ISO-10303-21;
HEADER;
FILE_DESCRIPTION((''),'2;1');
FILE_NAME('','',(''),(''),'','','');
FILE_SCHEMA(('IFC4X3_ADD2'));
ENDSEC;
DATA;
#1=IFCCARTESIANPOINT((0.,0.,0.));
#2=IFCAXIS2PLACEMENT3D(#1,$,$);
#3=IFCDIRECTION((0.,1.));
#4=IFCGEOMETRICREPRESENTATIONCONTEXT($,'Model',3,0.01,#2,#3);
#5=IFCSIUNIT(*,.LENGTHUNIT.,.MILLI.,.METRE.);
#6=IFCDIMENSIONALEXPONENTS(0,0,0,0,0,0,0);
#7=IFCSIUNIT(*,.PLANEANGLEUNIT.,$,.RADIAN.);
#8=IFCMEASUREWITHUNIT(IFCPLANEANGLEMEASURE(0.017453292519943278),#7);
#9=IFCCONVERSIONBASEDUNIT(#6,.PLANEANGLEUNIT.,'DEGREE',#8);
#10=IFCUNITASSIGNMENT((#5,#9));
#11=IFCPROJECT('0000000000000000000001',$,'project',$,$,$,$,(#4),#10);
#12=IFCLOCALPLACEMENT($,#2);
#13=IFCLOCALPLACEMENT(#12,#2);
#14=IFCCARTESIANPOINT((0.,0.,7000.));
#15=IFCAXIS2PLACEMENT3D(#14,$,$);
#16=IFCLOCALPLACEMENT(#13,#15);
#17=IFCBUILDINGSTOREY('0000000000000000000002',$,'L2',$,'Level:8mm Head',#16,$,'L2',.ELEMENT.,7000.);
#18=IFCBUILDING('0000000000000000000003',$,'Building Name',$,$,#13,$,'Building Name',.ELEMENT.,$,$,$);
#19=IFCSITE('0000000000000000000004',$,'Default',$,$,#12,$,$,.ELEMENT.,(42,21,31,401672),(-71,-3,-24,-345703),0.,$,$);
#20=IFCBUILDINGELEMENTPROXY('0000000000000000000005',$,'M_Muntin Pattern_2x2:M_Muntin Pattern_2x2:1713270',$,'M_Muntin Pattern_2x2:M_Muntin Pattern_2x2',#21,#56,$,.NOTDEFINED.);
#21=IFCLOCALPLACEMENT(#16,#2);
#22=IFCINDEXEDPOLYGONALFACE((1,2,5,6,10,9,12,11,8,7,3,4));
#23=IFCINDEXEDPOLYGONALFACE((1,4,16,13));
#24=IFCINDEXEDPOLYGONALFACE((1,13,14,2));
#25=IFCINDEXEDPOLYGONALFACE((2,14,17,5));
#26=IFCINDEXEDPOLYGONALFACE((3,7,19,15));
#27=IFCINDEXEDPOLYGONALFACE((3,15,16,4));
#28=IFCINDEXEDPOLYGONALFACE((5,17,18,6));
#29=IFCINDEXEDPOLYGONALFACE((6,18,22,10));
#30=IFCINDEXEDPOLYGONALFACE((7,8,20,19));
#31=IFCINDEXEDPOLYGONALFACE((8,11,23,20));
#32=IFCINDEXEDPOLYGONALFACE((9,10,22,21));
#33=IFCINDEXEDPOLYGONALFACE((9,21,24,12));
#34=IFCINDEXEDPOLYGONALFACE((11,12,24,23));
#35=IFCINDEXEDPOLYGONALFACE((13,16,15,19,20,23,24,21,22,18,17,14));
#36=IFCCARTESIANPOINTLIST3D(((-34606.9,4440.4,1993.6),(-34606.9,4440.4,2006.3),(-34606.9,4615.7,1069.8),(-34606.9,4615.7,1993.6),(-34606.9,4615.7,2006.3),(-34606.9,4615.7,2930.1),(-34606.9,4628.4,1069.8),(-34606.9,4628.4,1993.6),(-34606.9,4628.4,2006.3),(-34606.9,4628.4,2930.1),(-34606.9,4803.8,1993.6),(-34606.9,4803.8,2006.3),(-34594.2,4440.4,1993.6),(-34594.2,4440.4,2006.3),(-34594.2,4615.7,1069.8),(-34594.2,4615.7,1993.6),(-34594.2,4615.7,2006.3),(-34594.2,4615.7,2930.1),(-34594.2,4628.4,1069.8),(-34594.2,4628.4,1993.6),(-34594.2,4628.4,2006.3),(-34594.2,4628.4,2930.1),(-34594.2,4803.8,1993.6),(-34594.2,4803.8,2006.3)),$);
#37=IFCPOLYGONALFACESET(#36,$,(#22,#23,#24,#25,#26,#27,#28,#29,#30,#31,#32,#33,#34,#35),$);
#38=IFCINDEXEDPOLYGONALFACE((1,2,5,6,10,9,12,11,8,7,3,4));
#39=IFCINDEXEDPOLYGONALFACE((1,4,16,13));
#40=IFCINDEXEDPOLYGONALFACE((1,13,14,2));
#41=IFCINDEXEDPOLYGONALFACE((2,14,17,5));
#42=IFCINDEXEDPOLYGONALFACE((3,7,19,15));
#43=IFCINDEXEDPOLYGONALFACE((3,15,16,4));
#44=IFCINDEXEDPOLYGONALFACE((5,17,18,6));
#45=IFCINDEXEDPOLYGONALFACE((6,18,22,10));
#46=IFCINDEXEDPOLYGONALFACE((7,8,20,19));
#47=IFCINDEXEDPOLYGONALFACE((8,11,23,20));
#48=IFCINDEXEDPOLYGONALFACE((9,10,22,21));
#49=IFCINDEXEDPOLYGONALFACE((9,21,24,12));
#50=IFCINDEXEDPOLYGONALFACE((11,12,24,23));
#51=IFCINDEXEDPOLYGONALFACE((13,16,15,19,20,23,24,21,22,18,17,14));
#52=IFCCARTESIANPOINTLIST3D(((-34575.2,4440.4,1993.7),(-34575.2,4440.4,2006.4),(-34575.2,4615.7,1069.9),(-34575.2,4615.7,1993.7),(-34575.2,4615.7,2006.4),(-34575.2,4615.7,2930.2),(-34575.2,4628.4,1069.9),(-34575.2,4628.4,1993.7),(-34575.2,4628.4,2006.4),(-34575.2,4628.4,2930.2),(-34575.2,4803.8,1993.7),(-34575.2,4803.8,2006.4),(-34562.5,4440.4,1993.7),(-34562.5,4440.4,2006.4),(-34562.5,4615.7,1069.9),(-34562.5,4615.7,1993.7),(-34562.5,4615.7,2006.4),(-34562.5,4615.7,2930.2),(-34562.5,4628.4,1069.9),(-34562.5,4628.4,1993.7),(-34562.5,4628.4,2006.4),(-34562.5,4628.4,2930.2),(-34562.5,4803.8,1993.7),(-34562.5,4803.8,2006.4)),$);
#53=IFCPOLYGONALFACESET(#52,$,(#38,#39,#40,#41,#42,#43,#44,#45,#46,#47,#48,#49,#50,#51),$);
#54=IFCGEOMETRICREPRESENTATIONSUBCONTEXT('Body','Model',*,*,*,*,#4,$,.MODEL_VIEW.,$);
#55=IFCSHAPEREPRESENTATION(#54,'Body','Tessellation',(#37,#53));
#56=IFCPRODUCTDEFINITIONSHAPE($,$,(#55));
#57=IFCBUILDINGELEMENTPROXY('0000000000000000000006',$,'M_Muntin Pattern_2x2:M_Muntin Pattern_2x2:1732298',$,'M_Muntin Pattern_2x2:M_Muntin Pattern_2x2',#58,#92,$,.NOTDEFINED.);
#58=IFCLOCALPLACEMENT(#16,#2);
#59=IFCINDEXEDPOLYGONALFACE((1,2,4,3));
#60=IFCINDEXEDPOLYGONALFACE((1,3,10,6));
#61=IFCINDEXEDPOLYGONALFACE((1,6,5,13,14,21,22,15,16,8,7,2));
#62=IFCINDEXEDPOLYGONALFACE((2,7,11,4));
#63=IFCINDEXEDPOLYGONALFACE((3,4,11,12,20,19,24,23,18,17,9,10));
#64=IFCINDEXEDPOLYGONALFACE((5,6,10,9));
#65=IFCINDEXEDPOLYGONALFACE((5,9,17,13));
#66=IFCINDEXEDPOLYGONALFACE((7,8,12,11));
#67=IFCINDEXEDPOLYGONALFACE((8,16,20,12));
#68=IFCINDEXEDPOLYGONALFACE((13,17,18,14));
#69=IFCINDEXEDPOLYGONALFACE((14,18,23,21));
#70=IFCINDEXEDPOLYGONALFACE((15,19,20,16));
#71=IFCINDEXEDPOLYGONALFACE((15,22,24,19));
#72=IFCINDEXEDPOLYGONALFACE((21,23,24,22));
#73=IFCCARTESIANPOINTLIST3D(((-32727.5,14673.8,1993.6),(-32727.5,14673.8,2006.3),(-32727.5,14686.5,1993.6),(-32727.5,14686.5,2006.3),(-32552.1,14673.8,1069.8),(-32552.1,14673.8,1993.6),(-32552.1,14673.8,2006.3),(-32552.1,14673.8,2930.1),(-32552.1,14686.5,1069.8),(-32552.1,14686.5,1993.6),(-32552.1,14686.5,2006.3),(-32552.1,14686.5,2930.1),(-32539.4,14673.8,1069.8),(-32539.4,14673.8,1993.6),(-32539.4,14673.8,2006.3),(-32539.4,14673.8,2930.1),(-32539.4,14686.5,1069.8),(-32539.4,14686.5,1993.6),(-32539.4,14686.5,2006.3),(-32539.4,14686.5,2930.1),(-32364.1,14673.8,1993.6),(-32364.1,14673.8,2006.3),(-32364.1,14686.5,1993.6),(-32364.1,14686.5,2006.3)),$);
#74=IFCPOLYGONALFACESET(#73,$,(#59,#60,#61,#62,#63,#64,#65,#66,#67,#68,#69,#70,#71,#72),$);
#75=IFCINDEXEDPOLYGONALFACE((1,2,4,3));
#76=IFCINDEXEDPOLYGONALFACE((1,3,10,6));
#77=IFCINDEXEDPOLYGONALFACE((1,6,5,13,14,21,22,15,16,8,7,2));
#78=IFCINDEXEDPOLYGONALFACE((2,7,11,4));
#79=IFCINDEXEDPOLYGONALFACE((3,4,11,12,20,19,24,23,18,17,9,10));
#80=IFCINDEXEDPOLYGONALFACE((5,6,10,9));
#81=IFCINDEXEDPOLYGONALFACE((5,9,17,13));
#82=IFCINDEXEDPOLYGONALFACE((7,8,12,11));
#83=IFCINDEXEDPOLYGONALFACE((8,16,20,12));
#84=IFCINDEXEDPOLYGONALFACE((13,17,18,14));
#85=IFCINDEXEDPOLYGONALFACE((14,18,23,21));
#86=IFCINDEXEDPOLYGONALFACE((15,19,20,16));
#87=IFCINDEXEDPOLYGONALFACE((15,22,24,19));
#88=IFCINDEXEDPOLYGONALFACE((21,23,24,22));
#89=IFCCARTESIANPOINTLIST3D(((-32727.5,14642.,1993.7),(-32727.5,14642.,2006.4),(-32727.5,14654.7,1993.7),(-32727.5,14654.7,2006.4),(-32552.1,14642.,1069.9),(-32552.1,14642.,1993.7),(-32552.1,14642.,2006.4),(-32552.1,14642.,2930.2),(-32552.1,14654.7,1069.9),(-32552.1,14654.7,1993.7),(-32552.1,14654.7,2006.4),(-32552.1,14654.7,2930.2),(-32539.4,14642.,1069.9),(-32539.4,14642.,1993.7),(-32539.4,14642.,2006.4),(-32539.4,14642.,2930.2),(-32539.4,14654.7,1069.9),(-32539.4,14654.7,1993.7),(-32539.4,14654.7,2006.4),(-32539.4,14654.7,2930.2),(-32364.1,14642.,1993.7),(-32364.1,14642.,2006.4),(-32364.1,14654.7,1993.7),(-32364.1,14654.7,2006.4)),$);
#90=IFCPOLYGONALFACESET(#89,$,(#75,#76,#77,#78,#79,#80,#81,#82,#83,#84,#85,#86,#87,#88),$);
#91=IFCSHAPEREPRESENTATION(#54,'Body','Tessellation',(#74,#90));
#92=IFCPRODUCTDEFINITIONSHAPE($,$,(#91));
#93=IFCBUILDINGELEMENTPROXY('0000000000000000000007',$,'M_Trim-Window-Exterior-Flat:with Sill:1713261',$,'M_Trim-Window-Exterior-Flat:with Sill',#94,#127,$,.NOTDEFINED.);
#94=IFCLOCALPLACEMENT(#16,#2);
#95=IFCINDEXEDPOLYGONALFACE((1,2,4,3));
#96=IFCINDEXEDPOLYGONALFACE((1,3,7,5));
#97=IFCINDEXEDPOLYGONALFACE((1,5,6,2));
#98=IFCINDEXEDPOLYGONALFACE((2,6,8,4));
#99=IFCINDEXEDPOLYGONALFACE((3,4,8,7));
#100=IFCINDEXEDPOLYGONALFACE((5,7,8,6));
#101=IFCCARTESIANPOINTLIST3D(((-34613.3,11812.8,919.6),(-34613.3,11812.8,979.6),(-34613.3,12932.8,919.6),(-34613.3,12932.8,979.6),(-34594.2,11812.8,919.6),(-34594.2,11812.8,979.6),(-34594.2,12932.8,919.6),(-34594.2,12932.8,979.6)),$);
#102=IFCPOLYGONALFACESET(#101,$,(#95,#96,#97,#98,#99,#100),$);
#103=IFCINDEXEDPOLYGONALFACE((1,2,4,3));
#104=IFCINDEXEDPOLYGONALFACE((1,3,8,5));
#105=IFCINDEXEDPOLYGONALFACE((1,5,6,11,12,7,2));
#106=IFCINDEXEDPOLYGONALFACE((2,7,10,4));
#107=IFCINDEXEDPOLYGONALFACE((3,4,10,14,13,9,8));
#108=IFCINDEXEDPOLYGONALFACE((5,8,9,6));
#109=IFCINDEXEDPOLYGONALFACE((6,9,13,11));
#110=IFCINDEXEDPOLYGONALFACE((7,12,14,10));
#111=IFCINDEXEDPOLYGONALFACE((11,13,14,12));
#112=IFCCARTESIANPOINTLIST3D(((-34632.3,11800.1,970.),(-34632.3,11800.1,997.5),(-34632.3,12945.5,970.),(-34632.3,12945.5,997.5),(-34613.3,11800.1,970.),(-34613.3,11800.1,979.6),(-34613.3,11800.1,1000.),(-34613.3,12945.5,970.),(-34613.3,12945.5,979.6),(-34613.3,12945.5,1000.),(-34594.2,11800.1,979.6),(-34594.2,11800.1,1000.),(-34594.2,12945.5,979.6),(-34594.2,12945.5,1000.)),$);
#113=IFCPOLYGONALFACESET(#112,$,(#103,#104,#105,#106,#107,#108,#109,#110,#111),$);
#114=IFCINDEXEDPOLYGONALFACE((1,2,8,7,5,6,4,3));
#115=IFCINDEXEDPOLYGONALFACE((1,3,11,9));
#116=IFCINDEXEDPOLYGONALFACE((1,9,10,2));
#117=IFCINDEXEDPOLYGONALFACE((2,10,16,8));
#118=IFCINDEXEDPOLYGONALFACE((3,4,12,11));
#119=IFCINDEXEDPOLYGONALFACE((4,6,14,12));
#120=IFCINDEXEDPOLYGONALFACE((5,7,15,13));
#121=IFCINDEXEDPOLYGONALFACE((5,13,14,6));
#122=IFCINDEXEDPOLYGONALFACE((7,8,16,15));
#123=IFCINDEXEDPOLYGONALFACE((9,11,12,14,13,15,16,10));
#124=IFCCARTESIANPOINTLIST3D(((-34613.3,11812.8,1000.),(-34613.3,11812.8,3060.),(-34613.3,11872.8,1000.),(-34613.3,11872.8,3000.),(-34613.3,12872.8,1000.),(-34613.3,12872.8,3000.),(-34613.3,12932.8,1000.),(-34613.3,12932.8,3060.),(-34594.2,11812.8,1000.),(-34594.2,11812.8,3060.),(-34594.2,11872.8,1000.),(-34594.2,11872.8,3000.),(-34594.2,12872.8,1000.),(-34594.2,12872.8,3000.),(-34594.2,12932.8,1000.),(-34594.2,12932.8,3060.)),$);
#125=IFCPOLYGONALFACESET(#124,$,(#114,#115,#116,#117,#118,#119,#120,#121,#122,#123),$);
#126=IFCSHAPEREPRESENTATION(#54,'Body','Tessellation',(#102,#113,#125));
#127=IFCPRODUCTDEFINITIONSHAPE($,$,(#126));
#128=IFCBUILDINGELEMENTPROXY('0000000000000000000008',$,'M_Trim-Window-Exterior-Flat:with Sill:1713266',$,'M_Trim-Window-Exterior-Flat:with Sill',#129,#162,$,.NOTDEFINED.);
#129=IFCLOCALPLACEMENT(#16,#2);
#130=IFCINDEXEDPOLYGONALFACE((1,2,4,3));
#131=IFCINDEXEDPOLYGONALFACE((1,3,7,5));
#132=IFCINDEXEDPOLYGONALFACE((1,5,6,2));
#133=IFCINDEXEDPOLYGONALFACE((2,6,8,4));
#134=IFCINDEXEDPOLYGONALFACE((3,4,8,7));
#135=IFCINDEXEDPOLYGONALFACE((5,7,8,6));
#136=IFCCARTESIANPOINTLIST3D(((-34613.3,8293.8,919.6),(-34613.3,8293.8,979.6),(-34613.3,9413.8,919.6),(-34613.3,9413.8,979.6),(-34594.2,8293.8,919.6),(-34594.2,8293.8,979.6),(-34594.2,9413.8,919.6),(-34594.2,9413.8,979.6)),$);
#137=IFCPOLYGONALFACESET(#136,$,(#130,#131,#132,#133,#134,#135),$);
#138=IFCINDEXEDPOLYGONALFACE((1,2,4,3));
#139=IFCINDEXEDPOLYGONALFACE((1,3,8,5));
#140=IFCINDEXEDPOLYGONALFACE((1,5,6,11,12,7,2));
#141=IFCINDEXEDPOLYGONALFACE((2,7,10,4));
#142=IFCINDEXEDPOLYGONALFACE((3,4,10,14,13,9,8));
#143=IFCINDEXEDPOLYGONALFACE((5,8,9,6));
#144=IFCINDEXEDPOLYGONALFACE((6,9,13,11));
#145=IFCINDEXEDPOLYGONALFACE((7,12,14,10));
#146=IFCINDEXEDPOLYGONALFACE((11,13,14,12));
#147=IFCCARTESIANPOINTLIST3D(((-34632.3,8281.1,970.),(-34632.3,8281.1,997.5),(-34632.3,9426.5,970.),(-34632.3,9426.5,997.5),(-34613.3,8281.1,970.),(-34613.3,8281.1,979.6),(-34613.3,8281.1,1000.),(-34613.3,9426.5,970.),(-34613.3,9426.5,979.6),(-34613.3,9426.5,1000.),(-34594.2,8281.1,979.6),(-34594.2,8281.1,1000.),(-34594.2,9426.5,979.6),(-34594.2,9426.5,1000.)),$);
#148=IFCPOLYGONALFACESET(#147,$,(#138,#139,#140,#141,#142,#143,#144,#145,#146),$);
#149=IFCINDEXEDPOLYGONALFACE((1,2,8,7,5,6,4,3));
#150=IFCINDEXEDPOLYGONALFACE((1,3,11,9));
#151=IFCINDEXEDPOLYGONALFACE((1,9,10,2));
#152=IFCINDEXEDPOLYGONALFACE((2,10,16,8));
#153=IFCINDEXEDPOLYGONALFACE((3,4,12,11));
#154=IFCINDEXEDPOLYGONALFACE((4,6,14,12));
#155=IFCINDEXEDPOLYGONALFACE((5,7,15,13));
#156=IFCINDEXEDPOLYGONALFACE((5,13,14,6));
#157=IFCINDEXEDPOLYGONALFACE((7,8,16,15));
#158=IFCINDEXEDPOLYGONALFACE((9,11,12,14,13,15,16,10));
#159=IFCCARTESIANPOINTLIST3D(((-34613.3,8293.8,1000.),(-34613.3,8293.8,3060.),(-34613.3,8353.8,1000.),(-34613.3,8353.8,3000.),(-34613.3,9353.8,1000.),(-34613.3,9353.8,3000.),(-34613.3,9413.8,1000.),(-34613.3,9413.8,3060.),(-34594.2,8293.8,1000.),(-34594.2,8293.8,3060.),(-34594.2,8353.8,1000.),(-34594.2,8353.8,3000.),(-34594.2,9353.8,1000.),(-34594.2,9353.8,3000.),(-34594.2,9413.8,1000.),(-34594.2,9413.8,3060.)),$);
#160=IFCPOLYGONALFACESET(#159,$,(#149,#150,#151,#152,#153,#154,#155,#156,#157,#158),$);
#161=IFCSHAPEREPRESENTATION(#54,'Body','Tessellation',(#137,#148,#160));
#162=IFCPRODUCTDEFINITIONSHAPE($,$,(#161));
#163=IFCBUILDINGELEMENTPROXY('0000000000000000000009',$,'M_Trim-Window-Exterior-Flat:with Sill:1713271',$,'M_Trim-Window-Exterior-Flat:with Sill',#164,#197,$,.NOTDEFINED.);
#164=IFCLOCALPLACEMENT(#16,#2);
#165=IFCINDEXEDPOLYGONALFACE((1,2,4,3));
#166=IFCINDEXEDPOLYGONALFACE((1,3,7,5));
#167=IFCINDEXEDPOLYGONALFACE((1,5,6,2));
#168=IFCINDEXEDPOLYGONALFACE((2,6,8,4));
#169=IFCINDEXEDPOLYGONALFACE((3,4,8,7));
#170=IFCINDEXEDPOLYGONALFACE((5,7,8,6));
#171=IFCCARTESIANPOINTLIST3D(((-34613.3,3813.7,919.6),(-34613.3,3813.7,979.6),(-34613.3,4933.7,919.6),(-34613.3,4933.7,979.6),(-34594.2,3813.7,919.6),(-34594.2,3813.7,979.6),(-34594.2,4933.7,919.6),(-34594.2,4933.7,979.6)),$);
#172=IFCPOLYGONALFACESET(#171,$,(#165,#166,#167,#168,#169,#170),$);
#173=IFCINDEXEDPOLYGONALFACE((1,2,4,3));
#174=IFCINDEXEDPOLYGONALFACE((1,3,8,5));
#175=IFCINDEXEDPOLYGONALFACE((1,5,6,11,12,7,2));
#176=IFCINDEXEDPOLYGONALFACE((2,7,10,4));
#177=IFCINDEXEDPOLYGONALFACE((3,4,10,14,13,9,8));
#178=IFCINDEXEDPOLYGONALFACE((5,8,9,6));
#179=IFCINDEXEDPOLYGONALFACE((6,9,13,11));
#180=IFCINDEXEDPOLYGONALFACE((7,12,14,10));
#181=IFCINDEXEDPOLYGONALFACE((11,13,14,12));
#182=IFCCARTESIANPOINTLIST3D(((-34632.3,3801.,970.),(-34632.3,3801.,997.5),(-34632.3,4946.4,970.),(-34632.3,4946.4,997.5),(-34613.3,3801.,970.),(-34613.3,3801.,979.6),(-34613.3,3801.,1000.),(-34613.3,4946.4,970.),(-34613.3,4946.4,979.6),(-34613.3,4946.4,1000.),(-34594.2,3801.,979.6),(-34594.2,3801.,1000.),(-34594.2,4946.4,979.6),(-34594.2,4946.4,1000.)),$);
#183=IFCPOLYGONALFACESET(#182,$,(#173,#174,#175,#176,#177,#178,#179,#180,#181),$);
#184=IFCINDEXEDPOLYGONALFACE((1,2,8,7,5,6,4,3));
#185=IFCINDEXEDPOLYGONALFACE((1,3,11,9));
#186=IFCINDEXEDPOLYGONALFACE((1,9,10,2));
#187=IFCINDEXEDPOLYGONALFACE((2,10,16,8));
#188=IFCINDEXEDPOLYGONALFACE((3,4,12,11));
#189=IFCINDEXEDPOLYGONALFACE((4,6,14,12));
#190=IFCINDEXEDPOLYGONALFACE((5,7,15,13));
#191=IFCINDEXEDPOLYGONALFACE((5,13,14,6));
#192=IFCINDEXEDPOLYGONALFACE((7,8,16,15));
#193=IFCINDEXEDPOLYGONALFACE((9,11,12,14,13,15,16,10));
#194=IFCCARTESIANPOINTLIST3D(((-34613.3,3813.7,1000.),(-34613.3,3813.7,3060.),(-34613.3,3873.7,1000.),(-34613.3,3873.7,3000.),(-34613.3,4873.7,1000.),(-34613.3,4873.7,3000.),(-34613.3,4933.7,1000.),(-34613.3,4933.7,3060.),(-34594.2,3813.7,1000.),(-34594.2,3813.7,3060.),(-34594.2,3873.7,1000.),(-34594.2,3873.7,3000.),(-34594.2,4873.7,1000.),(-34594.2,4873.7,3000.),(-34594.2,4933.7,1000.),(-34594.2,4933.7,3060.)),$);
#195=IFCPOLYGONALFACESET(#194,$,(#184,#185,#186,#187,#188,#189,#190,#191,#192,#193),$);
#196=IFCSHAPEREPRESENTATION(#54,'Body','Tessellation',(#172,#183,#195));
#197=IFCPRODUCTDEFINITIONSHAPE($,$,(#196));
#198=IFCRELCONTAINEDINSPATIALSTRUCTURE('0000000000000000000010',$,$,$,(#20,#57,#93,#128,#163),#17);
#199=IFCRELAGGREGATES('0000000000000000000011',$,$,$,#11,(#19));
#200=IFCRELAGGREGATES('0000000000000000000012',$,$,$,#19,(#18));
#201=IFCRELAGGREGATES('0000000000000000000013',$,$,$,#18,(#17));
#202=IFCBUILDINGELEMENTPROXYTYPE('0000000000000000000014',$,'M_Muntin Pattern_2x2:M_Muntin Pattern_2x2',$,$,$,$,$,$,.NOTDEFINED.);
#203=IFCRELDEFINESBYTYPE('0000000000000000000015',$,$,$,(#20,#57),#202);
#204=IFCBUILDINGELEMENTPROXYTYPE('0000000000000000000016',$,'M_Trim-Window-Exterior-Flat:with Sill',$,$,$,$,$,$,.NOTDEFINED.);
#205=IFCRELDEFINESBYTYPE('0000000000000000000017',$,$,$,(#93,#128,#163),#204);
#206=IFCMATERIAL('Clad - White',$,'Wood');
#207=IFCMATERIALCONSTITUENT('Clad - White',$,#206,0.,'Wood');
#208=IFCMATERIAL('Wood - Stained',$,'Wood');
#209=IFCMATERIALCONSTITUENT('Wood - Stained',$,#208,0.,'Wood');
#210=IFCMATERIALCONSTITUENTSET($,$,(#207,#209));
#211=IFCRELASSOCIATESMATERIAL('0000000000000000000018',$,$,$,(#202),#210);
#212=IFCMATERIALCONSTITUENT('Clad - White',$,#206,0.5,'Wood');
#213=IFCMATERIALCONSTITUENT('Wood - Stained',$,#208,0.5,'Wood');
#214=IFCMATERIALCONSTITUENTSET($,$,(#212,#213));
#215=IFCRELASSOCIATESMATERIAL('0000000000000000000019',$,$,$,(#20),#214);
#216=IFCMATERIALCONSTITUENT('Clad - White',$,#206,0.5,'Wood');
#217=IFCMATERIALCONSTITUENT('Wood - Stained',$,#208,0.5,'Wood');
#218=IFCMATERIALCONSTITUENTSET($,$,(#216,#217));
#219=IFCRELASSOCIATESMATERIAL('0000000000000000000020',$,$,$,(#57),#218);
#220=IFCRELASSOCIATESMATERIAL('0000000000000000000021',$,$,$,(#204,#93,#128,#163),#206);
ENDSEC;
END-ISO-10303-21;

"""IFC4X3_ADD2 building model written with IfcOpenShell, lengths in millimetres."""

from ifc_helpers import new_model, entity, si_unit, converted_unit, direction, frame, frame_2d, origin, place, context, subcontext, project, spatial, polyline, rectangle, outline, extrude, source, transform, mapped, material, constituent, constituent_set, type_object, type_shapes, element, save


model = new_model("IFC4X3_ADD2")

# Units and contexts
model_context = context("Model", 3, precision=0.01, world=origin(), true_north=direction((0.0, 1.0)))
body_context = subcontext(model_context, "Body", "Model", "MODEL_VIEW")
ifc_project = project(units=[si_unit("LENGTHUNIT", "METRE", prefix="MILLI"), converted_unit("PLANEANGLEUNIT", "DEGREE", entity("IfcPlaneAngleMeasure", 0.017453292519943278), si_unit("PLANEANGLEUNIT", "RADIAN"), dimensions=[0, 0, 0, 0, 0, 0, 0])], contexts=[model_context])

# Site, building, storey
site_placement = place(None, origin())
site = spatial("IfcSite", under=ifc_project, at=site_placement, Name="Default", CompositionType="ELEMENT", RefLatitude=(42, 21, 31, 401672), RefLongitude=(-71, -3, -24, -345703), RefElevation=0.0)
building_placement = place(site_placement, origin())
building = spatial("IfcBuilding", under=site, at=building_placement, Name="Building Name", LongName="Building Name", CompositionType="ELEMENT")
storey_placement = place(building_placement, frame((0.0, 0.0, 7000.0)))
storey = spatial("IfcBuildingStorey", under=building, at=storey_placement, Name="L2", ObjectType="Level:8mm Head", LongName="L2", CompositionType="ELEMENT", Elevation=7000.0)

# Building element proxies
ifc_material_1 = material(Name="Clad - White", Category="Wood")
ifc_material_2 = material(Name="Wood - Stained", Category="Wood")
ifc_constituent_1 = constituent(ifc_material_1, Name="Clad - White", Category="Wood", fraction=0.0)
ifc_constituent_2 = constituent(ifc_material_2, Name="Wood - Stained", Category="Wood", fraction=0.0)
ifc_constituent_set_1 = constituent_set(constituents=[ifc_constituent_1, ifc_constituent_2])
building_element_proxy_type_1 = type_object("IfcBuildingElementProxyType", Name="M_Muntin Pattern_2x2:M_Muntin Pattern_2x2", PredefinedType="NOTDEFINED", material=ifc_constituent_set_1)
shared_shape_1 = source(origin(), body_context, "Body", "SweptSolid", [
    extrude(outline(polyline([(6.4, -6.4), (930.1, -6.4), (930.1, 6.3), (6.4, 6.3), (6.4, 181.7), (-6.3, 181.7), (-6.3, 6.3), (-930.2, 6.3), (-930.2, -6.4), (-6.3, -6.4), (-6.3, -181.7), (6.4, -181.7), (6.4, -6.4)])), frame((0.0, -22.2, 930.1), z_axis=(0.0, 1.0, 0.0), x_axis=(0.0, 0.0, 1.0)), (0.0, 0.0, 1.0), 12.7),
    extrude(outline(polyline([(6.4, -6.4), (930.2, -6.4), (930.2, 6.3), (6.4, 6.3), (6.4, 181.7), (-6.3, 181.7), (-6.3, 6.3), (-930.2, 6.3), (-930.2, -6.4), (-6.3, -6.4), (-6.3, -181.7), (6.4, -181.7), (6.4, -6.4)])), frame((0.0, 9.5, 930.2), z_axis=(0.0, 1.0, 0.0), x_axis=(0.0, 0.0, 1.0)), (0.0, 0.0, 1.0), 12.7),
])
type_shapes(building_element_proxy_type_1, [shared_shape_1])
ifc_constituent_3 = constituent(ifc_material_1, Name="Clad - White", Category="Wood", fraction=0.5)
ifc_constituent_4 = constituent(ifc_material_2, Name="Wood - Stained", Category="Wood", fraction=0.5)
ifc_constituent_set_2 = constituent_set(constituents=[ifc_constituent_3, ifc_constituent_4])
proxy_1_placement = place(storey_placement, frame((-34584.7, 4622.1, 1069.9), z_axis=(0.0, 0.0, 1.0), x_axis=(0.0, -1.0, 0.0)))
element("IfcBuildingElementProxy", 1, at=proxy_1_placement, inside=storey, type_object=building_element_proxy_type_1, material=ifc_constituent_set_2, Name="M_Muntin Pattern_2x2:M_Muntin Pattern_2x2:1713270", ObjectType="M_Muntin Pattern_2x2:M_Muntin Pattern_2x2", PredefinedType="NOTDEFINED", context=body_context, shape_type="MappedRepresentation", body=[
    mapped(shared_shape_1, transform((0.0, 0.0, 0.0), scale=1.0)),
])
ifc_constituent_5 = constituent(ifc_material_1, Name="Clad - White", Category="Wood", fraction=0.5)
ifc_constituent_6 = constituent(ifc_material_2, Name="Wood - Stained", Category="Wood", fraction=0.5)
ifc_constituent_set_3 = constituent_set(constituents=[ifc_constituent_5, ifc_constituent_6])
proxy_2_placement = place(storey_placement, frame((-32545.8, 14664.3, 1069.9), z_axis=(0.0, 0.0, 1.0), x_axis=(-1.0, 0.0, 0.0)))
element("IfcBuildingElementProxy", 2, at=proxy_2_placement, inside=storey, type_object=building_element_proxy_type_1, material=ifc_constituent_set_3, Name="M_Muntin Pattern_2x2:M_Muntin Pattern_2x2:1732298", ObjectType="M_Muntin Pattern_2x2:M_Muntin Pattern_2x2", PredefinedType="NOTDEFINED", context=body_context, shape_type="MappedRepresentation", body=[
    mapped(shared_shape_1, transform((0.0, 0.0, 0.0), scale=1.0)),
])
building_element_proxy_type_2 = type_object("IfcBuildingElementProxyType", Name="M_Trim-Window-Exterior-Flat:with Sill", PredefinedType="NOTDEFINED", material=ifc_material_1)
shared_shape_2 = source(origin(), body_context, "Body", "SweptSolid", [
    extrude(rectangle(XDim=1120.0, YDim=60.0, at=frame_2d((0.0, 0.0), x_axis=(1.0, 0.0))), frame((0.0, -2050.4, 0.0), z_axis=(0.0, 0.0, 1.0), x_axis=(-1.0, 0.0, 0.0)), (0.0, 0.0, 1.0), 19.0),
    extrude(outline(polyline([(-19.0, -15.2), (0.0, -15.2), (0.0, -5.7), (19.0, -5.7), (19.0, 14.8), (0.0, 14.8), (-19.0, 12.3), (-19.0, -15.2)])), frame((-572.7, -2014.8, 19.0), z_axis=(1.0, 0.0, 0.0), x_axis=(0.0, 0.0, -1.0)), (0.0, 0.0, 1.0), 1145.4),
    extrude(outline(polyline([(-1045.0, -560.0), (1015.0, -560.0), (1015.0, -500.0), (-985.0, -500.0), (-985.0, 500.0), (1015.0, 500.0), (1015.0, 560.0), (-1045.0, 560.0), (-1045.0, -560.0)])), frame((0.0, -985.0, 0.0), z_axis=(0.0, 0.0, 1.0), x_axis=(0.0, -1.0, 0.0)), (0.0, 0.0, 1.0), 19.0),
])
type_shapes(building_element_proxy_type_2, [shared_shape_2])
for number, where, z_axis, x_axis, name in (
    (3, (-34594.2, 12372.8, 3000.0), (-1.0, 0.0, 0.0), (0.0, -1.0, 0.0), "M_Trim-Window-Exterior-Flat:with Sill:1713261"),
    (4, (-34594.2, 8853.8, 3000.0), (-1.0, 0.0, 0.0), (0.0, -1.0, 0.0), "M_Trim-Window-Exterior-Flat:with Sill:1713266"),
    (5, (-34594.2, 4373.7, 3000.0), (-1.0, 0.0, 0.0), (0.0, -1.0, 0.0), "M_Trim-Window-Exterior-Flat:with Sill:1713271"),
):
    element("IfcBuildingElementProxy", number, at=place(storey_placement, frame(where, z_axis=z_axis, x_axis=x_axis)), inside=storey, type_object=building_element_proxy_type_2, material=ifc_material_1, Name=name, ObjectType="M_Trim-Window-Exterior-Flat:with Sill", PredefinedType="NOTDEFINED", context=body_context, shape_type="MappedRepresentation", body=[
        mapped(shared_shape_2, transform((0.0, 0.0, 0.0), scale=1.0)),
    ])

save(model, "model.ifc")
